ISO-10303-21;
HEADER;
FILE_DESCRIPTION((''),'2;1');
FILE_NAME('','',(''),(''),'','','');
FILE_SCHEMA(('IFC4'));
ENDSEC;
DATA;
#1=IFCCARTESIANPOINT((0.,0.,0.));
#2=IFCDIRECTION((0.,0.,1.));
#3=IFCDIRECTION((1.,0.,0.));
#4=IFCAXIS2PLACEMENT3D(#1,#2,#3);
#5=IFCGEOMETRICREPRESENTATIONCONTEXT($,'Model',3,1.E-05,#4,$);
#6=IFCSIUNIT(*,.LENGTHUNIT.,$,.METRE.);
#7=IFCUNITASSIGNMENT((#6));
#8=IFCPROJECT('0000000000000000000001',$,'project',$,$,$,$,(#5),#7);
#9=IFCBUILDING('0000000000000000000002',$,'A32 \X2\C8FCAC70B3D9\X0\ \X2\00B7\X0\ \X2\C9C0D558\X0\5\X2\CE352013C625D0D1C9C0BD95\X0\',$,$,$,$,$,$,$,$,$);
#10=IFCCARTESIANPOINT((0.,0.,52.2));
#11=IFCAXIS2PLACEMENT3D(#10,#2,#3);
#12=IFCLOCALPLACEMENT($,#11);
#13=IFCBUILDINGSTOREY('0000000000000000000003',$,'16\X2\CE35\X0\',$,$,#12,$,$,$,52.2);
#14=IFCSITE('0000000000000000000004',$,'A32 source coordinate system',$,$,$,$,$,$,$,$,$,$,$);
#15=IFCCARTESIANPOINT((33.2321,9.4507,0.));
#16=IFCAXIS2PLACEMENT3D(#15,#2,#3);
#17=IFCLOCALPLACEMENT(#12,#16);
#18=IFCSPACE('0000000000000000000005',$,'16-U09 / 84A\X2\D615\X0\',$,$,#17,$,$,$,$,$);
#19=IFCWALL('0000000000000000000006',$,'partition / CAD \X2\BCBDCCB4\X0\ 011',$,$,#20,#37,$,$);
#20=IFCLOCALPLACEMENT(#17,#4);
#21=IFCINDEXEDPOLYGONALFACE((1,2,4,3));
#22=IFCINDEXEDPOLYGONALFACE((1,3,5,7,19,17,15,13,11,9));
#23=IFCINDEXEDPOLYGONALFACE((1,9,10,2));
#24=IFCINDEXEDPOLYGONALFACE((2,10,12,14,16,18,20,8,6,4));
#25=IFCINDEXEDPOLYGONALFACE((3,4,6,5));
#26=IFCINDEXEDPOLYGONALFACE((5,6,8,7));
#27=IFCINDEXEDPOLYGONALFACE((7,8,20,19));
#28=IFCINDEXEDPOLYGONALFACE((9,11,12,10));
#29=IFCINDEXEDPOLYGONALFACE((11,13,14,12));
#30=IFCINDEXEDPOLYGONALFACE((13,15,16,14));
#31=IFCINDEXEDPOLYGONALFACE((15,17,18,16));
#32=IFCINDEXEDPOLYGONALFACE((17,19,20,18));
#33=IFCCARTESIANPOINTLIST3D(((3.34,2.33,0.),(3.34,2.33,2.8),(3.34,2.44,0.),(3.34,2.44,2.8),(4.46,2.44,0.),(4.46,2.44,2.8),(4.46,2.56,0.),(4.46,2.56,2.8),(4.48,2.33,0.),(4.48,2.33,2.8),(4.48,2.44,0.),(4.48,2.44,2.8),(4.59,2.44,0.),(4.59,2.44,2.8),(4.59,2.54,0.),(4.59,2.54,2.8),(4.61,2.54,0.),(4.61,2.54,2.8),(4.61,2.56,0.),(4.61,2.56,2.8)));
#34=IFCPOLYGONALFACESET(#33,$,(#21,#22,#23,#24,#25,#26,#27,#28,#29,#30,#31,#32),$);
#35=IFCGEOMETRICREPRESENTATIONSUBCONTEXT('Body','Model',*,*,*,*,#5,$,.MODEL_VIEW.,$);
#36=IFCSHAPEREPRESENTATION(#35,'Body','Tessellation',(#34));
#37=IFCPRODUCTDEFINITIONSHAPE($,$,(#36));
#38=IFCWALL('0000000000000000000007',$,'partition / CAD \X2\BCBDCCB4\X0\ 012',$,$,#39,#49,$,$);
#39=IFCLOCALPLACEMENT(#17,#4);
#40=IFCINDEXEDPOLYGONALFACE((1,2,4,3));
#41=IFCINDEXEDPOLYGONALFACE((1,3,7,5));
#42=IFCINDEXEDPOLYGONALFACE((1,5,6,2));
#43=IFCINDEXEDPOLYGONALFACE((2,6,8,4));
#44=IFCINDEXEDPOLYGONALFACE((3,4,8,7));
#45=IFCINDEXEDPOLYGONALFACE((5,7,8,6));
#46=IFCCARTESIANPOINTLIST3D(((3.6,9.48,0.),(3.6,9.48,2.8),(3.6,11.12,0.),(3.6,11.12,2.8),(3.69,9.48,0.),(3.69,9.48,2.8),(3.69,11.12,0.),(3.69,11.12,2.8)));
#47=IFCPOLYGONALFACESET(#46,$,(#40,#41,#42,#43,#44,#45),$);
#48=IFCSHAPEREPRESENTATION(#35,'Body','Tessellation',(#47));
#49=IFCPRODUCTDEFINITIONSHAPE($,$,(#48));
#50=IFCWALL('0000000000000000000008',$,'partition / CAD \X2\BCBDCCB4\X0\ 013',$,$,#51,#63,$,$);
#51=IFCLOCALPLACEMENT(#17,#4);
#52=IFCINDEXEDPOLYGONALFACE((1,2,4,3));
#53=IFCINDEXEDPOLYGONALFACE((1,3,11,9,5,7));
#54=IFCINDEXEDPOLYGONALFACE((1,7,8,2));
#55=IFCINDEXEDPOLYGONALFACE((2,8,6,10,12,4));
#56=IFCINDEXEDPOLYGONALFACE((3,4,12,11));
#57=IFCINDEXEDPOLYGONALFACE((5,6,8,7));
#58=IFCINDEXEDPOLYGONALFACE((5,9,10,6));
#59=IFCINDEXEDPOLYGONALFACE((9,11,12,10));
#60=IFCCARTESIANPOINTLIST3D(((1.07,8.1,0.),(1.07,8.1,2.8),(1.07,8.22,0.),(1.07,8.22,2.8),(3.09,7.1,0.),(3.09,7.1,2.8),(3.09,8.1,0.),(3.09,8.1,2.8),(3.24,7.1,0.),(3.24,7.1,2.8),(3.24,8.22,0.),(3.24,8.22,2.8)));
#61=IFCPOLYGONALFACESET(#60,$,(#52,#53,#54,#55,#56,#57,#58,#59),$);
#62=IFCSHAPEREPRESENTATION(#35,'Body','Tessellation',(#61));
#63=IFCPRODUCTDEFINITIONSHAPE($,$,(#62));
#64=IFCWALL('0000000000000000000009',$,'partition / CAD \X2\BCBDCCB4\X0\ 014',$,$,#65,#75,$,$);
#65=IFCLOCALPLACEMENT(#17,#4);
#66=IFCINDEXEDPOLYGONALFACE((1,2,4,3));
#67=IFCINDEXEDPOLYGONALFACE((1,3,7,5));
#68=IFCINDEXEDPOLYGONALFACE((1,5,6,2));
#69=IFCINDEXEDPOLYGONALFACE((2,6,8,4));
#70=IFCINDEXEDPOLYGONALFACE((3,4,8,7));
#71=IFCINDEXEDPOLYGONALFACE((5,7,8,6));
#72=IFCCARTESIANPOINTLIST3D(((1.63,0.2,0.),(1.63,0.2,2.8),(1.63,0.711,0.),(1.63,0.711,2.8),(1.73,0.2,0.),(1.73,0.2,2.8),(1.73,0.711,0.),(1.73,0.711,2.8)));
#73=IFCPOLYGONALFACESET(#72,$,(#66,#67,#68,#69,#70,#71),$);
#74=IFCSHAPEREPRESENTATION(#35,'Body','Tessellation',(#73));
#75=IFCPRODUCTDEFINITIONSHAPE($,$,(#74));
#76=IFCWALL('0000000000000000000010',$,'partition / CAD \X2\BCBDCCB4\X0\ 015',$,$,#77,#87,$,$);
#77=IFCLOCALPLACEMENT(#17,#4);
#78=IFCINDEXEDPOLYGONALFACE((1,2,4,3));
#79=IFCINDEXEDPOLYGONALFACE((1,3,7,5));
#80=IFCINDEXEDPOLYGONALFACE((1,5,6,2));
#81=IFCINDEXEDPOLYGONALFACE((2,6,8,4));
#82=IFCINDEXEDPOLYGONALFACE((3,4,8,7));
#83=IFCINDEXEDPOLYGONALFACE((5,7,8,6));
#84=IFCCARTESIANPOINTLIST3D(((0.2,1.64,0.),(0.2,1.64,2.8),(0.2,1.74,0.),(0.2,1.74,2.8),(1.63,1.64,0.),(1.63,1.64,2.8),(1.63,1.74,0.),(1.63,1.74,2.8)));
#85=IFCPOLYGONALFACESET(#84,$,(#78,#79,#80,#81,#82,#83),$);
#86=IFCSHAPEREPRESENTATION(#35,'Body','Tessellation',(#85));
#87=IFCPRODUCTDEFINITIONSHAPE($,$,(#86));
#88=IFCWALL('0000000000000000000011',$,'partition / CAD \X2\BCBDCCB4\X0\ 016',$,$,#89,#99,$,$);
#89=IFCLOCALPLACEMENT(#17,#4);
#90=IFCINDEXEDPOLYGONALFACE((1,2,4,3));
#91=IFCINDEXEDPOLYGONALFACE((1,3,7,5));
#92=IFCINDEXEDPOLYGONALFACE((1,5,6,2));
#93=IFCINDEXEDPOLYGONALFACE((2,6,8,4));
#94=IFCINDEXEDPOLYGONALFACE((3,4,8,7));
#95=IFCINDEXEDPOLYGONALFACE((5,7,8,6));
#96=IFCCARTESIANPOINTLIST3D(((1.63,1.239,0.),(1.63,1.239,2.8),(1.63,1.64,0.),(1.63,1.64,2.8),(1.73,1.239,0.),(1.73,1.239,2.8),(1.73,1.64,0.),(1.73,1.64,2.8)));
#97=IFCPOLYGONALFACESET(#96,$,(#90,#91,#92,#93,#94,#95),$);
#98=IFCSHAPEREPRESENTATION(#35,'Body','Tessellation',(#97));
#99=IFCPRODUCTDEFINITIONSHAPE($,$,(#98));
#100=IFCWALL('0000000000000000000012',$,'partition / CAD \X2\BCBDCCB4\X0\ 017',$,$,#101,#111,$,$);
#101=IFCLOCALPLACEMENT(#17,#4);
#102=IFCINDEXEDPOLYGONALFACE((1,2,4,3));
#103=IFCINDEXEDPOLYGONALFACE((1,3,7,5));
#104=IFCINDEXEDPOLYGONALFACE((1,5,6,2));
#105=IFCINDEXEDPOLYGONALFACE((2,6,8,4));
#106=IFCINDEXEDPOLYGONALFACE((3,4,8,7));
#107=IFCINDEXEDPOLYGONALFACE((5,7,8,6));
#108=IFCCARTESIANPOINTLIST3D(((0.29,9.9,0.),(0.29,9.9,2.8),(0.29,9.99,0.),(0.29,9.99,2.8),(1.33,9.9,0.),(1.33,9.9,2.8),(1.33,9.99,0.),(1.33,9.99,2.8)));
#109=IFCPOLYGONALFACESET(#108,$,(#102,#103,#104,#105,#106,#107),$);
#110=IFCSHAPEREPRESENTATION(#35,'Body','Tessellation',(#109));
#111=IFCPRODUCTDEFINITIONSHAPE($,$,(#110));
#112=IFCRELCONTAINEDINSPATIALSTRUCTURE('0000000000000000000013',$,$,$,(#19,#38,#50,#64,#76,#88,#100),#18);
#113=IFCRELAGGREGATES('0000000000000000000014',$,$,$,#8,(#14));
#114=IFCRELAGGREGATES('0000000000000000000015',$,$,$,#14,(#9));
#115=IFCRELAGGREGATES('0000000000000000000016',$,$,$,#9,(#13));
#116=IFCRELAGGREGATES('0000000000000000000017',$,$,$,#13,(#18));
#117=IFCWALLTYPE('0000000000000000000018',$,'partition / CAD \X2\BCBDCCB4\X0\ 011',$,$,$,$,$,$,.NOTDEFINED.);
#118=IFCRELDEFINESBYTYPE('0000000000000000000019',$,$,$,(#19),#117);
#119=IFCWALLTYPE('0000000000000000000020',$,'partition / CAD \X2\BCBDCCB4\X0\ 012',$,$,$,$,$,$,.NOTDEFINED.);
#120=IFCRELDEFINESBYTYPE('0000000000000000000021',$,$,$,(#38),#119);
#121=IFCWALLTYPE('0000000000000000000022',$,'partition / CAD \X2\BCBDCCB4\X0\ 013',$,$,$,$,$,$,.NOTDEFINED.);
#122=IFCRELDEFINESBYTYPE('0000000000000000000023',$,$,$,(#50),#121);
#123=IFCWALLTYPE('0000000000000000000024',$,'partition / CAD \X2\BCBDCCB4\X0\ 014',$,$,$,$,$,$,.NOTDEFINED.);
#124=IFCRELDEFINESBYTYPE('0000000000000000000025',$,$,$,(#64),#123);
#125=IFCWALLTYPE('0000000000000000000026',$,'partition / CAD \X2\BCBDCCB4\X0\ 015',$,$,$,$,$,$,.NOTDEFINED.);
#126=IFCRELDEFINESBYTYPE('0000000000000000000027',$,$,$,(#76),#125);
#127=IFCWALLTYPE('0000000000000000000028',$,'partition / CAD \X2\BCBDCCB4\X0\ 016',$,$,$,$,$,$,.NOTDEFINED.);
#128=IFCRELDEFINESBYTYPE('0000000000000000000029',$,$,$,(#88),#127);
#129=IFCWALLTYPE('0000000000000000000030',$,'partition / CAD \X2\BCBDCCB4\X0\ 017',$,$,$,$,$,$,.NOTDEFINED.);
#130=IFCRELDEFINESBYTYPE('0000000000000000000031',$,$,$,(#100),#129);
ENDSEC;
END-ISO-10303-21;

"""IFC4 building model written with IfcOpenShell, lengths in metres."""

from ifc_helpers import new_model, si_unit, frame, origin, origin_with_axes, place, context, subcontext, project, spatial, polyline, outline, extrude, source, transform, mapped, type_object, type_shapes, element, save


model = new_model("IFC4")

# Units and contexts
model_context = context("Model", 3, precision=1e-05, world=origin_with_axes())
body_context = subcontext(model_context, "Body", "Model", "MODEL_VIEW")
ifc_project = project(units=[si_unit("LENGTHUNIT", "METRE")], contexts=[model_context])

# Site, building, storey, space
storey_placement = place(None, frame((0.0, 0.0, 52.2), z_axis=(0.0, 0.0, 1.0), x_axis=(1.0, 0.0, 0.0)))
space_placement = place(storey_placement, frame((33.2321, 9.4507, 0.0), z_axis=(0.0, 0.0, 1.0), x_axis=(1.0, 0.0, 0.0)))
site = spatial("IfcSite", under=ifc_project, Name="A32 source coordinate system")
building = spatial("IfcBuilding", under=site, Name="A32 주거동 · 지하5층–옥탑지붕")
storey = spatial("IfcBuildingStorey", under=building, at=storey_placement, Name="16층", Elevation=52.2)
space = spatial("IfcSpace", under=storey, at=space_placement, Name="16-U09 / 84A형")

# Walls
wall_type_1 = type_object("IfcWallType", Name="partition / CAD 벽체 011", PredefinedType="NOTDEFINED")
shared_shape_1 = source(origin(), body_context, "Body", "SweptSolid", [
    extrude(outline(polyline([(3.34, 2.33), (3.34, 2.44), (4.46, 2.44), (4.46, 2.56), (4.61, 2.56), (4.61, 2.54), (4.59, 2.54), (4.59, 2.44), (4.48, 2.44), (4.48, 2.33), (3.34, 2.33)])), origin(), (0.0, 0.0, 1.0), 2.8),
])
type_shapes(wall_type_1, [shared_shape_1])
wall_1_placement = place(space_placement, origin_with_axes())
element("IfcWall", 1, at=wall_1_placement, inside=space, type_object=wall_type_1, Name="partition / CAD 벽체 011", context=body_context, shape_type="MappedRepresentation", body=[
    mapped(shared_shape_1, transform((0.0, 0.0, 0.0), scale=1.0)),
])
wall_type_2 = type_object("IfcWallType", Name="partition / CAD 벽체 012", PredefinedType="NOTDEFINED")
shared_shape_2 = source(origin(), body_context, "Body", "SweptSolid", [
    extrude(outline(polyline([(3.6, 11.12), (3.69, 11.12), (3.69, 9.48), (3.6, 9.48), (3.6, 11.12)])), origin(), (0.0, 0.0, 1.0), 2.8),
])
type_shapes(wall_type_2, [shared_shape_2])
wall_2_placement = place(space_placement, origin_with_axes())
element("IfcWall", 2, at=wall_2_placement, inside=space, type_object=wall_type_2, Name="partition / CAD 벽체 012", context=body_context, shape_type="MappedRepresentation", body=[
    mapped(shared_shape_2, transform((0.0, 0.0, 0.0), scale=1.0)),
])
wall_type_3 = type_object("IfcWallType", Name="partition / CAD 벽체 013", PredefinedType="NOTDEFINED")
shared_shape_3 = source(origin(), body_context, "Body", "SweptSolid", [
    extrude(outline(polyline([(3.09, 8.1), (1.07, 8.1), (1.07, 8.22), (3.24, 8.22), (3.24, 7.1), (3.09, 7.1), (3.09, 8.1)])), origin(), (0.0, 0.0, 1.0), 2.8),
])
type_shapes(wall_type_3, [shared_shape_3])
wall_3_placement = place(space_placement, origin_with_axes())
element("IfcWall", 3, at=wall_3_placement, inside=space, type_object=wall_type_3, Name="partition / CAD 벽체 013", context=body_context, shape_type="MappedRepresentation", body=[
    mapped(shared_shape_3, transform((0.0, 0.0, 0.0), scale=1.0)),
])
wall_type_4 = type_object("IfcWallType", Name="partition / CAD 벽체 014", PredefinedType="NOTDEFINED")
shared_shape_4 = source(origin(), body_context, "Body", "SweptSolid", [
    extrude(outline(polyline([(1.73, 0.2), (1.63, 0.2), (1.63, 0.711), (1.73, 0.711), (1.73, 0.2)])), origin(), (0.0, 0.0, 1.0), 2.8),
])
type_shapes(wall_type_4, [shared_shape_4])
wall_4_placement = place(space_placement, origin_with_axes())
element("IfcWall", 4, at=wall_4_placement, inside=space, type_object=wall_type_4, Name="partition / CAD 벽체 014", context=body_context, shape_type="MappedRepresentation", body=[
    mapped(shared_shape_4, transform((0.0, 0.0, 0.0), scale=1.0)),
])
wall_type_5 = type_object("IfcWallType", Name="partition / CAD 벽체 015", PredefinedType="NOTDEFINED")
shared_shape_5 = source(origin(), body_context, "Body", "SweptSolid", [
    extrude(outline(polyline([(1.63, 1.74), (1.63, 1.64), (0.2, 1.64), (0.2, 1.74), (1.63, 1.74)])), origin(), (0.0, 0.0, 1.0), 2.8),
])
type_shapes(wall_type_5, [shared_shape_5])
wall_5_placement = place(space_placement, origin_with_axes())
element("IfcWall", 5, at=wall_5_placement, inside=space, type_object=wall_type_5, Name="partition / CAD 벽체 015", context=body_context, shape_type="MappedRepresentation", body=[
    mapped(shared_shape_5, transform((0.0, 0.0, 0.0), scale=1.0)),
])
wall_type_6 = type_object("IfcWallType", Name="partition / CAD 벽체 016", PredefinedType="NOTDEFINED")
shared_shape_6 = source(origin(), body_context, "Body", "SweptSolid", [
    extrude(outline(polyline([(1.73, 1.239), (1.63, 1.239), (1.63, 1.64), (1.73, 1.64), (1.73, 1.239)])), origin(), (0.0, 0.0, 1.0), 2.8),
])
type_shapes(wall_type_6, [shared_shape_6])
wall_6_placement = place(space_placement, origin_with_axes())
element("IfcWall", 6, at=wall_6_placement, inside=space, type_object=wall_type_6, Name="partition / CAD 벽체 016", context=body_context, shape_type="MappedRepresentation", body=[
    mapped(shared_shape_6, transform((0.0, 0.0, 0.0), scale=1.0)),
])
wall_type_7 = type_object("IfcWallType", Name="partition / CAD 벽체 017", PredefinedType="NOTDEFINED")
shared_shape_7 = source(origin(), body_context, "Body", "SweptSolid", [
    extrude(outline(polyline([(1.33, 9.99), (1.33, 9.9), (0.29, 9.9), (0.29, 9.99), (1.33, 9.99)])), origin(), (0.0, 0.0, 1.0), 2.8),
])
type_shapes(wall_type_7, [shared_shape_7])
wall_7_placement = place(space_placement, origin_with_axes())
element("IfcWall", 7, at=wall_7_placement, inside=space, type_object=wall_type_7, Name="partition / CAD 벽체 017", context=body_context, shape_type="MappedRepresentation", body=[
    mapped(shared_shape_7, transform((0.0, 0.0, 0.0), scale=1.0)),
])

save(model, "model.ifc")
